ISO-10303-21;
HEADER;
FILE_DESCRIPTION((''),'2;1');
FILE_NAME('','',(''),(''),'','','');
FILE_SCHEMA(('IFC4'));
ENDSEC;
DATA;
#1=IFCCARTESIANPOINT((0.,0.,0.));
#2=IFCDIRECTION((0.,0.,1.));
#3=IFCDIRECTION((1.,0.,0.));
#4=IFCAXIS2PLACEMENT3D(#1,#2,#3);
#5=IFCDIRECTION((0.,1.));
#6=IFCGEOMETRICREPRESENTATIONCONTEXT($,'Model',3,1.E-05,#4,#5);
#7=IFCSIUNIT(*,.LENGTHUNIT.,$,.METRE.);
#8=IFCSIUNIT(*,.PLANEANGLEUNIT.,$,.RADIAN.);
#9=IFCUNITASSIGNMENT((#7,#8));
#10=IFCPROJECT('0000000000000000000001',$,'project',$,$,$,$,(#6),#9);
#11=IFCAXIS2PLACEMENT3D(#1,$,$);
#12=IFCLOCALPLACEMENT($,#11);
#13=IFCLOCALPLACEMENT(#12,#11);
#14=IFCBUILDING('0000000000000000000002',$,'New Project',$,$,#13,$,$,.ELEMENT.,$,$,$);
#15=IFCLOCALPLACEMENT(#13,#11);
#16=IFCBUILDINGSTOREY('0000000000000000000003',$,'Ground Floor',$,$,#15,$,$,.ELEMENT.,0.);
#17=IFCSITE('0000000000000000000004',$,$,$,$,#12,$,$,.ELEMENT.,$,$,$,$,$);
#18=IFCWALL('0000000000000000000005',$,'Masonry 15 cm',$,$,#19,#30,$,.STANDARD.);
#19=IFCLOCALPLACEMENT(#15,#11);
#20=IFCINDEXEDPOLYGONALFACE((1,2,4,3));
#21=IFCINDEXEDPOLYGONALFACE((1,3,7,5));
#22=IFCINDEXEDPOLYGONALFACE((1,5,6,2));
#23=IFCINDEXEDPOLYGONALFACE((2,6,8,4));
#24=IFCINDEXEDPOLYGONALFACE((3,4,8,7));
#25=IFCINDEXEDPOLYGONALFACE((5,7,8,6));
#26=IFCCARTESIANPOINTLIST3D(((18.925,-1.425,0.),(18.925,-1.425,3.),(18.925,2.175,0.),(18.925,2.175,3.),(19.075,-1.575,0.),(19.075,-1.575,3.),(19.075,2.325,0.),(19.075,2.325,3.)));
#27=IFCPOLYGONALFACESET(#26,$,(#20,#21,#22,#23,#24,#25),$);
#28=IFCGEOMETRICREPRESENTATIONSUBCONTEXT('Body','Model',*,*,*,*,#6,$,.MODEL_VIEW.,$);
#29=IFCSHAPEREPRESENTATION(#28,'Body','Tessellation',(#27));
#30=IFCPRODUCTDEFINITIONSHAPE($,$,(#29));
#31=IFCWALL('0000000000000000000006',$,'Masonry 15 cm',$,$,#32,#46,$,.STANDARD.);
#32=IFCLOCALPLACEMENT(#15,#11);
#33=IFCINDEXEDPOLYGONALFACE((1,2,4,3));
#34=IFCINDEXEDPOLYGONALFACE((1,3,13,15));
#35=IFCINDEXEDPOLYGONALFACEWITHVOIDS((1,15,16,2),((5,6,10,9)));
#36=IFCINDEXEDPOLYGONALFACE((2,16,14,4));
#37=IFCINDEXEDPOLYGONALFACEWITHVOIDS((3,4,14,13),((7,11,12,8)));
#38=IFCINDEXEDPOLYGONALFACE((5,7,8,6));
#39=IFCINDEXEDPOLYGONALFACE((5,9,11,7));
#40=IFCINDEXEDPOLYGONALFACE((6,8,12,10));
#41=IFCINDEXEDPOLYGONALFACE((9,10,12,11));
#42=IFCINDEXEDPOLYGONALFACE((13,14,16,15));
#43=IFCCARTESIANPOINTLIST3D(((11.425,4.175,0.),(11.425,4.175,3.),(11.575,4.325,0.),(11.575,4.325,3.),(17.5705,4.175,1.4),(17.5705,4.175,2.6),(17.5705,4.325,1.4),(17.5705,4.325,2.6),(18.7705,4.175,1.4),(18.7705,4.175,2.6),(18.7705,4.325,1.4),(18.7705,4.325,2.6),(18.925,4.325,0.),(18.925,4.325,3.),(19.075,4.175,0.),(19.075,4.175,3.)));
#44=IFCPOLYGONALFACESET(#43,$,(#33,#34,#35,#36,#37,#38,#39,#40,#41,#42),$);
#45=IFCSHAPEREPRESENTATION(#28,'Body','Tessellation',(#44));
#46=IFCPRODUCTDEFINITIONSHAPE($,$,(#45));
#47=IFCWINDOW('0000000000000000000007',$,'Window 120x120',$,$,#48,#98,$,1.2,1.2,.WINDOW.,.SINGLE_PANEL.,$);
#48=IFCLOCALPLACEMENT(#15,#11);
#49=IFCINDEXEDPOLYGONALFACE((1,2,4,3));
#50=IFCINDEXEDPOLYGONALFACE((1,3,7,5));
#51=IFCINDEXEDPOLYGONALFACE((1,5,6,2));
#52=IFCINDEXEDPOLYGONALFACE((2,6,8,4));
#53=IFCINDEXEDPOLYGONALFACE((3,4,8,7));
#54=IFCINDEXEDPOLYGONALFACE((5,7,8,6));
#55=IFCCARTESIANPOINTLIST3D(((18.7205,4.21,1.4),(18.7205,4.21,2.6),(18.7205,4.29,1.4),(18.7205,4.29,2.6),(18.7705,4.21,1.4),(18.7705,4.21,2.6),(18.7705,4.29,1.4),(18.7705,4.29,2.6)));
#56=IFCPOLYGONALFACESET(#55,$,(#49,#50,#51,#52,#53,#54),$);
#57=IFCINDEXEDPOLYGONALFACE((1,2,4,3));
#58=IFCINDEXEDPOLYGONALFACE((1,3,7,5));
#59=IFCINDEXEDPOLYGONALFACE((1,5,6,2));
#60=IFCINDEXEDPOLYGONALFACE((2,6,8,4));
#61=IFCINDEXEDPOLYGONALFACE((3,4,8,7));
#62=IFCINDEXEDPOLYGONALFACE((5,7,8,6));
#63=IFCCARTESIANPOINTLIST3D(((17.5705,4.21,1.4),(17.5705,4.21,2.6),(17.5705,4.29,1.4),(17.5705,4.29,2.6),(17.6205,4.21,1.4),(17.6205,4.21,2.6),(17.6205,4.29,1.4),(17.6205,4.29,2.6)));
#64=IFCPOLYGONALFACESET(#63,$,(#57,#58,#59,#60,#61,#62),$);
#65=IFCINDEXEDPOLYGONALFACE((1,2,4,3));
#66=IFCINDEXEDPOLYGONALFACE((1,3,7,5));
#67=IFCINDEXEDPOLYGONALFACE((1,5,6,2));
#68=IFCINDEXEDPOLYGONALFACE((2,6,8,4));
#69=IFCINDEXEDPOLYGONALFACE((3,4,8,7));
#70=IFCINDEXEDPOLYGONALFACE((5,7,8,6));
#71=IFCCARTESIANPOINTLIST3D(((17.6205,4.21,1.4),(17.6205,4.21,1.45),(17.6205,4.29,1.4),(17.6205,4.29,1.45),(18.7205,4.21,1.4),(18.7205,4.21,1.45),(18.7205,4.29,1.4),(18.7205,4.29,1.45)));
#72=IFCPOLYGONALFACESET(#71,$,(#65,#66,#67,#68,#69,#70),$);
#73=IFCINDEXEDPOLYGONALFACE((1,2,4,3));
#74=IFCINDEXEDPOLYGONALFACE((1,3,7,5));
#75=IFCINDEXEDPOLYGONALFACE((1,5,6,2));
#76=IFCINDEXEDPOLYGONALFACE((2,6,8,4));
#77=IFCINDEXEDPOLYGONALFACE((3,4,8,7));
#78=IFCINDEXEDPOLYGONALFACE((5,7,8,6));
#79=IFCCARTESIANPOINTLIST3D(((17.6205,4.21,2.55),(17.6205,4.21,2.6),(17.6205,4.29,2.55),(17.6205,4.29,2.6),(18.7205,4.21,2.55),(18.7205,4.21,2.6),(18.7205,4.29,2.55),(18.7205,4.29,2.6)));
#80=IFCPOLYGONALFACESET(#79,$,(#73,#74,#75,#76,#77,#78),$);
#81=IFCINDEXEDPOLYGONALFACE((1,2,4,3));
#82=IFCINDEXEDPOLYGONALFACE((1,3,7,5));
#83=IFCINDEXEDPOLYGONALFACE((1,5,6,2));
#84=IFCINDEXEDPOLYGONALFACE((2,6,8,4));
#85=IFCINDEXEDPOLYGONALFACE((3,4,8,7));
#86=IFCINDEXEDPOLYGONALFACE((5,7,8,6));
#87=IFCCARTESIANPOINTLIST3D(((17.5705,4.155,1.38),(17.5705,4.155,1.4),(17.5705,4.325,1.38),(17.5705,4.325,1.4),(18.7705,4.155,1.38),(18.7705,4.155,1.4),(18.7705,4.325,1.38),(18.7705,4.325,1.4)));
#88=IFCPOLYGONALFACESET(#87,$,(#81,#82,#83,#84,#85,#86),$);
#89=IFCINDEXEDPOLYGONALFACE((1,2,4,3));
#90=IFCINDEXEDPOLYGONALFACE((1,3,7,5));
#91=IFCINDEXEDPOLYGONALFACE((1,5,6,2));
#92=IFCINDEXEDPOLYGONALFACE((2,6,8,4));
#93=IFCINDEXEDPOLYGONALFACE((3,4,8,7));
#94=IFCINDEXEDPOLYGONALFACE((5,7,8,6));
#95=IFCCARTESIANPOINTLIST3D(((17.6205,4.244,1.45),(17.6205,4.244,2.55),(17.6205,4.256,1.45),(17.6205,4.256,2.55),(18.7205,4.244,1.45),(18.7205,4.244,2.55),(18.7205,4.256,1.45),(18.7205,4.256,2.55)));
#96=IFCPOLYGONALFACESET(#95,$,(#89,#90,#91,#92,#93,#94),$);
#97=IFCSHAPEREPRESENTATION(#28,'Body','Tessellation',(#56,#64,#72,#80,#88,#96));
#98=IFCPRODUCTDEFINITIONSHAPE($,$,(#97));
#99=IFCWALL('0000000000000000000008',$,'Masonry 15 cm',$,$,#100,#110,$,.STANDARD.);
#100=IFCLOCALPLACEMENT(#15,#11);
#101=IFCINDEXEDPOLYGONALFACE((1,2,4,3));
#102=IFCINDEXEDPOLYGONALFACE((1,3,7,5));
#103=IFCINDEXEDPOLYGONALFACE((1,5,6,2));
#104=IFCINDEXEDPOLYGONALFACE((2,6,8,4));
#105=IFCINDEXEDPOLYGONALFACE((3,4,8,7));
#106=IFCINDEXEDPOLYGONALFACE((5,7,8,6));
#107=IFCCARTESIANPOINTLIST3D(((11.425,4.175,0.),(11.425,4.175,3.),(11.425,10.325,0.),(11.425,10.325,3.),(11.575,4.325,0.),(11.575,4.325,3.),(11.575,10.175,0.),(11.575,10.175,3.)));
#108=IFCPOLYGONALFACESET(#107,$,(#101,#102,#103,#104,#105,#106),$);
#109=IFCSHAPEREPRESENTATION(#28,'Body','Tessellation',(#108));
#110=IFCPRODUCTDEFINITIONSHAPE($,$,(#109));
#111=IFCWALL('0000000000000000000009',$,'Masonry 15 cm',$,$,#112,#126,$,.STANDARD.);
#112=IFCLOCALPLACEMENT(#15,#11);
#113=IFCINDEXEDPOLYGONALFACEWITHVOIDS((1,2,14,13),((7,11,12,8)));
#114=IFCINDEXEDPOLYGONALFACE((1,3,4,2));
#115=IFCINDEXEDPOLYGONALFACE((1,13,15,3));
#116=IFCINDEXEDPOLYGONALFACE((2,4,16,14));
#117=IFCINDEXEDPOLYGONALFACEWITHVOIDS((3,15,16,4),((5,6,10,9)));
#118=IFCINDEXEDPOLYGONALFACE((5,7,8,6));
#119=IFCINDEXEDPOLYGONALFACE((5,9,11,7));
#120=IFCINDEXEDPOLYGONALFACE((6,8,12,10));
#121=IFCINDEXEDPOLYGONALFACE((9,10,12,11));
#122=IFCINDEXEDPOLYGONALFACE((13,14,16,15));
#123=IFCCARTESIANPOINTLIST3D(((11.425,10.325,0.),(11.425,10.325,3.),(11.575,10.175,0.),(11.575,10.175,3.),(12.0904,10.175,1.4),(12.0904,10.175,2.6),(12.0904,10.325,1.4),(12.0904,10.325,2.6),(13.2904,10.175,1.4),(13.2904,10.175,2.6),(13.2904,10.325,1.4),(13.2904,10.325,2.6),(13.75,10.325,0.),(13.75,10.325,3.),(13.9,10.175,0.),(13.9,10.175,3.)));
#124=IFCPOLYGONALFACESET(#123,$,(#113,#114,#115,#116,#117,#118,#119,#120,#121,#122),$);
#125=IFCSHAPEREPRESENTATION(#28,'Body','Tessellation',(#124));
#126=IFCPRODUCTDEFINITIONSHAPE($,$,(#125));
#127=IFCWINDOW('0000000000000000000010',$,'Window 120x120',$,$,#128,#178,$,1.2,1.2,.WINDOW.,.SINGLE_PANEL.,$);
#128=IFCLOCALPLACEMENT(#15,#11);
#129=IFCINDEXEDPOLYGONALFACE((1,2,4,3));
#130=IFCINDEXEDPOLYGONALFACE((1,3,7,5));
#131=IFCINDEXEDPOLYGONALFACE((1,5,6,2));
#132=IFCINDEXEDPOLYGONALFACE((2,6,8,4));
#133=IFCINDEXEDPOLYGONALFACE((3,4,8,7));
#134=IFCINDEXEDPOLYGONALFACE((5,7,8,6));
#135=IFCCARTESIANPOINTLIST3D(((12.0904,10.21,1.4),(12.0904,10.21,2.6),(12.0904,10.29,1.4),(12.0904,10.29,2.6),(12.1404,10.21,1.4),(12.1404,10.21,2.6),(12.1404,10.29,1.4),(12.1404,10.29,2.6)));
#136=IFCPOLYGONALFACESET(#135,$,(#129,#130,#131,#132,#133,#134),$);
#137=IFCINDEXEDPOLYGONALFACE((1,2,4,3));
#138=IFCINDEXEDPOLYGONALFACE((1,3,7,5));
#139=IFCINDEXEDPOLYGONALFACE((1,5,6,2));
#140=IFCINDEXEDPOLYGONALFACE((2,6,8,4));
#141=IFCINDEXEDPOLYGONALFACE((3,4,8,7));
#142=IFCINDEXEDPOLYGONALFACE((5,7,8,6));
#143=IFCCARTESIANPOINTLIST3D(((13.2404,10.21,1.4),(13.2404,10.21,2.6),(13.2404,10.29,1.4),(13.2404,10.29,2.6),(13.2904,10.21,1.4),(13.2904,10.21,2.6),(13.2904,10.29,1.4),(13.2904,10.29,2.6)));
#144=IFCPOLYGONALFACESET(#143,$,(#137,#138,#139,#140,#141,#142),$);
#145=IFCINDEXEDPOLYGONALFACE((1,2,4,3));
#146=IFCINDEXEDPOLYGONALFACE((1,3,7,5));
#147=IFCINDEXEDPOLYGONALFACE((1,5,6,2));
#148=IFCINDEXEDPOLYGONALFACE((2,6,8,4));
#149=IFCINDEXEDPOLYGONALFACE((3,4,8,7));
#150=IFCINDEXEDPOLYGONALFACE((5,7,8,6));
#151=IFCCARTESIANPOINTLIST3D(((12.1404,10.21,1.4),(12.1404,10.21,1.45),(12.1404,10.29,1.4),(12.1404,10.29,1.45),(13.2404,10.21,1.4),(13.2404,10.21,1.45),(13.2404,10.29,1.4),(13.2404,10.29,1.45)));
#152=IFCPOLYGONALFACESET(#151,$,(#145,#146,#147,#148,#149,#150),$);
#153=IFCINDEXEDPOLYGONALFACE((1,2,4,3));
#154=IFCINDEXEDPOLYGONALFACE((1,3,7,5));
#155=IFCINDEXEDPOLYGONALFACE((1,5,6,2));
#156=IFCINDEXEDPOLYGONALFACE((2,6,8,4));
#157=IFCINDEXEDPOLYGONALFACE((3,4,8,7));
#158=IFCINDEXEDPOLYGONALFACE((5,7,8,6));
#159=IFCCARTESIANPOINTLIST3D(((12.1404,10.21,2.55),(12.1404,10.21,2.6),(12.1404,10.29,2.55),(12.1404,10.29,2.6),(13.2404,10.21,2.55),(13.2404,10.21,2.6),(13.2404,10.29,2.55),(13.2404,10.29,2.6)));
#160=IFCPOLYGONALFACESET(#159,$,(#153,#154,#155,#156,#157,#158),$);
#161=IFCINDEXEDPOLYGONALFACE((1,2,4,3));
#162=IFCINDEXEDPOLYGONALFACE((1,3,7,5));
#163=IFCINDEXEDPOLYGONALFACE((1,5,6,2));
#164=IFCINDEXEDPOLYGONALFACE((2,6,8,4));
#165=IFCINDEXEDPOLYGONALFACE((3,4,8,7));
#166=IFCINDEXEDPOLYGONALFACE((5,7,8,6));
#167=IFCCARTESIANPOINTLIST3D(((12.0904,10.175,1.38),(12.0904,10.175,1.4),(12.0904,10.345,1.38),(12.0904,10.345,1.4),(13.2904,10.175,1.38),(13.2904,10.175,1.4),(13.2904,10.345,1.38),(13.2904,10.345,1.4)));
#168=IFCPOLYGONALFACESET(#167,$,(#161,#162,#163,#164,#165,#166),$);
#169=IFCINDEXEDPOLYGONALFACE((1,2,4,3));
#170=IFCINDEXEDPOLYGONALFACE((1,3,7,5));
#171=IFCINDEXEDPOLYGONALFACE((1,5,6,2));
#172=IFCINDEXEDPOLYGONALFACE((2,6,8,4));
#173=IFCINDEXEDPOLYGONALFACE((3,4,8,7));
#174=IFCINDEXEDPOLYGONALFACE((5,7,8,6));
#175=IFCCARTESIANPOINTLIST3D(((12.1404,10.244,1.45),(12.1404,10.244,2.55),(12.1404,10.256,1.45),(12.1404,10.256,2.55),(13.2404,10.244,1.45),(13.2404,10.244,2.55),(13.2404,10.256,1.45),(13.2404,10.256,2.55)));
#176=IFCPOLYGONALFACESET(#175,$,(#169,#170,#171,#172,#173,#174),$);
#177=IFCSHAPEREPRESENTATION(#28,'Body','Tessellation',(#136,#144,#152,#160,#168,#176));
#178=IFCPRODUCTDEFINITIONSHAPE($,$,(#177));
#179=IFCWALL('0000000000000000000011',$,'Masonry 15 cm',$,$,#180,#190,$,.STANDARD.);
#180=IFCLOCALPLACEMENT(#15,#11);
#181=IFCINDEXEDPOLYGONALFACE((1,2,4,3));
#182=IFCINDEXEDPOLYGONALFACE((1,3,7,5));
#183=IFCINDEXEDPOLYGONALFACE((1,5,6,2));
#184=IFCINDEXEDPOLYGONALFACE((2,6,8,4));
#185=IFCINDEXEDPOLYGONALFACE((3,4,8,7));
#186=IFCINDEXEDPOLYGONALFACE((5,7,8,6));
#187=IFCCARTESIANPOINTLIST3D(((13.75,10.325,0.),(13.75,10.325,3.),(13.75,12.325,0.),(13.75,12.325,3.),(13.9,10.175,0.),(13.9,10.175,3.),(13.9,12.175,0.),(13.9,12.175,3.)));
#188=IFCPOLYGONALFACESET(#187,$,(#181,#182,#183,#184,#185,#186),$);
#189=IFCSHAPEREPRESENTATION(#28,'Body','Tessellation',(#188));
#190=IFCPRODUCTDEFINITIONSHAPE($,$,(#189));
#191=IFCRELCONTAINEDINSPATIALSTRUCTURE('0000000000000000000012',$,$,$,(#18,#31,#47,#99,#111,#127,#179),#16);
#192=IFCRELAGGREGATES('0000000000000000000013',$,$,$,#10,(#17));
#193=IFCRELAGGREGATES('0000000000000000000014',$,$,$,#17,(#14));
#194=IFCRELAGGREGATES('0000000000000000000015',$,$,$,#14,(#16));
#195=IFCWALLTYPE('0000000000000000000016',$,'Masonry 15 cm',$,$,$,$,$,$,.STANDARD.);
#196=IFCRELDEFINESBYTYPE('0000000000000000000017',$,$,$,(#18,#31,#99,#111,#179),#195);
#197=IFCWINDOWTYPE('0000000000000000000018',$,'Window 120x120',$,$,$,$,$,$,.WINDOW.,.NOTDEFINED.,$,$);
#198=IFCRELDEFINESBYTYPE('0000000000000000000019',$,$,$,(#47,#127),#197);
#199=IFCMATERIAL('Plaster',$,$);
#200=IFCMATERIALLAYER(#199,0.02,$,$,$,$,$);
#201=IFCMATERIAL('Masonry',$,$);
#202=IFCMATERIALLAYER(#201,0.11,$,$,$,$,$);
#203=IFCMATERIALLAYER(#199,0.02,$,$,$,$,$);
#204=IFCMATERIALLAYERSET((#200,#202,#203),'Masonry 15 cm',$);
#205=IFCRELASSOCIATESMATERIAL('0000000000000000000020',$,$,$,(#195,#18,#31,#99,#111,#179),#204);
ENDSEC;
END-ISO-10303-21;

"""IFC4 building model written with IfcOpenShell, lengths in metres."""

from ifc_helpers import new_model, si_unit, direction, frame, frame_2d, origin, origin_with_axes, place, context, subcontext, project, spatial, polyline, rectangle, outline, extrude, material, layer, layer_set, layer_usage, type_object, element, fill, save


model = new_model("IFC4")

# Units and contexts
model_context = context("Model", 3, precision=1e-05, world=origin_with_axes(), true_north=direction((0.0, 1.0)))
body_context = subcontext(model_context, "Body", "Model", "MODEL_VIEW")
ifc_project = project(units=[si_unit("LENGTHUNIT", "METRE"), si_unit("PLANEANGLEUNIT", "RADIAN")], contexts=[model_context])

# Site, building, storey
site_placement = place(None, origin())
site = spatial("IfcSite", under=ifc_project, at=site_placement, CompositionType="ELEMENT")
building_placement = place(site_placement, origin())
building = spatial("IfcBuilding", under=site, at=building_placement, Name="New Project", CompositionType="ELEMENT")
storey_placement = place(building_placement, origin())
storey = spatial("IfcBuildingStorey", under=building, at=storey_placement, Name="Ground Floor", CompositionType="ELEMENT", Elevation=0.0)

# Wall
ifc_material_1 = material(Name="Plaster")
ifc_layer_1 = layer(ifc_material_1, 0.02)
ifc_material_2 = material(Name="Masonry")
ifc_layer_2 = layer(ifc_material_2, 0.11)
ifc_layer_3 = layer(ifc_material_1, 0.02)
ifc_layer_set_1 = layer_set([ifc_layer_1, ifc_layer_2, ifc_layer_3], Name="Masonry 15 cm")
ifc_layer_usage_1 = layer_usage(ifc_layer_set_1, "AXIS2", "NEGATIVE", 0.075)
wall_type_1 = type_object("IfcWallType", Name="Masonry 15 cm", PredefinedType="STANDARD", material=ifc_layer_set_1)
wall_1_placement = place(storey_placement, frame((19.0, 2.25, 0.0), z_axis=(0.0, 0.0, 1.0), x_axis=(0.0, -1.0, 0.0)))
element("IfcWall", 1, at=wall_1_placement, inside=storey, type_object=wall_type_1, material=ifc_layer_usage_1, Name="Masonry 15 cm", PredefinedType="STANDARD", context=body_context, shape_type="SweptSolid", body=[
    extrude(outline(polyline([(0.075, -0.075), (3.675, -0.075), (3.825, 0.075), (-0.075, 0.075), (0.075, -0.075)])), origin(), (0.0, 0.0, 1.0), 3.0),
])

# Wall, opening, window
wall_2_placement = place(storey_placement, frame((19.0, 4.25, 0.0), z_axis=(0.0, 0.0, 1.0), x_axis=(-1.0, 0.0, 0.0)))
wall_2 = element("IfcWall", 2, at=wall_2_placement, inside=storey, type_object=wall_type_1, material=ifc_layer_usage_1, Name="Masonry 15 cm", PredefinedType="STANDARD", context=body_context, shape_type="SweptSolid", body=[
    extrude(outline(polyline([(0.075, -0.075), (7.425, -0.075), (7.575, 0.075), (-0.075, 0.075), (0.075, -0.075)])), origin(), (0.0, 0.0, 1.0), 3.0),
])
opening_1_placement = place(wall_2_placement, frame((0.2295, 0.0, 1.4)))
opening_1 = element("IfcOpeningElement", 3, at=opening_1_placement, cuts=wall_2, PredefinedType="OPENING", context=body_context, shape_type="SweptSolid", body=[
    extrude(rectangle(XDim=1.2, YDim=0.25, at=frame_2d((0.6, 0.0))), origin(), (0.0, 0.0, 1.0), 1.2),
])
window_type = type_object("IfcWindowType", Name="Window 120x120", PartitioningType="NOTDEFINED", PredefinedType="WINDOW")
window_1_placement = place(opening_1_placement, origin())
window_1 = element("IfcWindow", 4, at=window_1_placement, inside=storey, type_object=window_type, Name="Window 120x120", OverallHeight=1.2, OverallWidth=1.2, PartitioningType="SINGLE_PANEL", PredefinedType="WINDOW", context=body_context, shape_type="SweptSolid", body=[
    extrude(outline(polyline([(0.0, -0.04), (0.05, -0.04), (0.05, 0.04), (0.0, 0.04), (0.0, -0.04)])), origin(), (0.0, 0.0, 1.0), 1.2),
    extrude(outline(polyline([(1.15, -0.04), (1.2, -0.04), (1.2, 0.04), (1.15, 0.04), (1.15, -0.04)])), origin(), (0.0, 0.0, 1.0), 1.2),
    extrude(outline(polyline([(0.05, -0.04), (1.15, -0.04), (1.15, 0.04), (0.05, 0.04), (0.05, -0.04)])), origin(), (0.0, 0.0, 1.0), 0.05),
    extrude(outline(polyline([(0.05, -0.04), (1.15, -0.04), (1.15, 0.04), (0.05, 0.04), (0.05, -0.04)])), frame((0.0, 0.0, 1.15)), (0.0, 0.0, 1.0), 0.05),
    extrude(outline(polyline([(0.0, -0.075), (1.2, -0.075), (1.2, 0.095), (0.0, 0.095), (0.0, -0.075)])), frame((0.0, 0.0, -0.02)), (0.0, 0.0, 1.0), 0.02),
    extrude(outline(polyline([(0.05, -0.006), (1.15, -0.006), (1.15, 0.006), (0.05, 0.006), (0.05, -0.006)])), frame((0.0, 0.0, 0.05)), (0.0, 0.0, 1.0), 1.1),
])
fill(opening_1, window_1)

# Wall
wall_3_placement = place(storey_placement, frame((11.5, 4.25, 0.0), z_axis=(0.0, 0.0, 1.0), x_axis=(0.0, 1.0, 0.0)))
element("IfcWall", 5, at=wall_3_placement, inside=storey, type_object=wall_type_1, material=ifc_layer_usage_1, Name="Masonry 15 cm", PredefinedType="STANDARD", context=body_context, shape_type="SweptSolid", body=[
    extrude(outline(polyline([(0.075, -0.075), (5.925, -0.075), (6.075, 0.075), (-0.075, 0.075), (0.075, -0.075)])), origin(), (0.0, 0.0, 1.0), 3.0),
])

# Wall, opening, window
wall_4_placement = place(storey_placement, frame((11.5, 10.25, 0.0)))
wall_4 = element("IfcWall", 6, at=wall_4_placement, inside=storey, type_object=wall_type_1, material=ifc_layer_usage_1, Name="Masonry 15 cm", PredefinedType="STANDARD", context=body_context, shape_type="SweptSolid", body=[
    extrude(outline(polyline([(0.075, -0.075), (2.4, -0.075), (2.25, 0.075), (-0.075, 0.075), (0.075, -0.075)])), origin(), (0.0, 0.0, 1.0), 3.0),
])
opening_2_placement = place(wall_4_placement, frame((0.5904, 0.0, 1.4)))
opening_2 = element("IfcOpeningElement", 7, at=opening_2_placement, cuts=wall_4, PredefinedType="OPENING", context=body_context, shape_type="SweptSolid", body=[
    extrude(rectangle(XDim=1.2, YDim=0.25, at=frame_2d((0.6, 0.0))), origin(), (0.0, 0.0, 1.0), 1.2),
])
window_2_placement = place(opening_2_placement, origin())
window_2 = element("IfcWindow", 8, at=window_2_placement, inside=storey, type_object=window_type, Name="Window 120x120", OverallHeight=1.2, OverallWidth=1.2, PartitioningType="SINGLE_PANEL", PredefinedType="WINDOW", context=body_context, shape_type="SweptSolid", body=[
    extrude(outline(polyline([(0.0, -0.04), (0.05, -0.04), (0.05, 0.04), (0.0, 0.04), (0.0, -0.04)])), origin(), (0.0, 0.0, 1.0), 1.2),
    extrude(outline(polyline([(1.15, -0.04), (1.2, -0.04), (1.2, 0.04), (1.15, 0.04), (1.15, -0.04)])), origin(), (0.0, 0.0, 1.0), 1.2),
    extrude(outline(polyline([(0.05, -0.04), (1.15, -0.04), (1.15, 0.04), (0.05, 0.04), (0.05, -0.04)])), origin(), (0.0, 0.0, 1.0), 0.05),
    extrude(outline(polyline([(0.05, -0.04), (1.15, -0.04), (1.15, 0.04), (0.05, 0.04), (0.05, -0.04)])), frame((0.0, 0.0, 1.15)), (0.0, 0.0, 1.0), 0.05),
    extrude(outline(polyline([(0.0, -0.075), (1.2, -0.075), (1.2, 0.095), (0.0, 0.095), (0.0, -0.075)])), frame((0.0, 0.0, -0.02)), (0.0, 0.0, 1.0), 0.02),
    extrude(outline(polyline([(0.05, -0.006), (1.15, -0.006), (1.15, 0.006), (0.05, 0.006), (0.05, -0.006)])), frame((0.0, 0.0, 0.05)), (0.0, 0.0, 1.0), 1.1),
])
fill(opening_2, window_2)

# Wall
wall_5_placement = place(storey_placement, frame((13.825, 10.25, 0.0), z_axis=(0.0, 0.0, 1.0), x_axis=(0.0, 1.0, 0.0)))
element("IfcWall", 9, at=wall_5_placement, inside=storey, type_object=wall_type_1, material=ifc_layer_usage_1, Name="Masonry 15 cm", PredefinedType="STANDARD", context=body_context, shape_type="SweptSolid", body=[
    extrude(outline(polyline([(-0.075, -0.075), (1.925, -0.075), (2.075, 0.075), (0.075, 0.075), (-0.075, -0.075)])), origin(), (0.0, 0.0, 1.0), 3.0),
])

save(model, "model.ifc")
